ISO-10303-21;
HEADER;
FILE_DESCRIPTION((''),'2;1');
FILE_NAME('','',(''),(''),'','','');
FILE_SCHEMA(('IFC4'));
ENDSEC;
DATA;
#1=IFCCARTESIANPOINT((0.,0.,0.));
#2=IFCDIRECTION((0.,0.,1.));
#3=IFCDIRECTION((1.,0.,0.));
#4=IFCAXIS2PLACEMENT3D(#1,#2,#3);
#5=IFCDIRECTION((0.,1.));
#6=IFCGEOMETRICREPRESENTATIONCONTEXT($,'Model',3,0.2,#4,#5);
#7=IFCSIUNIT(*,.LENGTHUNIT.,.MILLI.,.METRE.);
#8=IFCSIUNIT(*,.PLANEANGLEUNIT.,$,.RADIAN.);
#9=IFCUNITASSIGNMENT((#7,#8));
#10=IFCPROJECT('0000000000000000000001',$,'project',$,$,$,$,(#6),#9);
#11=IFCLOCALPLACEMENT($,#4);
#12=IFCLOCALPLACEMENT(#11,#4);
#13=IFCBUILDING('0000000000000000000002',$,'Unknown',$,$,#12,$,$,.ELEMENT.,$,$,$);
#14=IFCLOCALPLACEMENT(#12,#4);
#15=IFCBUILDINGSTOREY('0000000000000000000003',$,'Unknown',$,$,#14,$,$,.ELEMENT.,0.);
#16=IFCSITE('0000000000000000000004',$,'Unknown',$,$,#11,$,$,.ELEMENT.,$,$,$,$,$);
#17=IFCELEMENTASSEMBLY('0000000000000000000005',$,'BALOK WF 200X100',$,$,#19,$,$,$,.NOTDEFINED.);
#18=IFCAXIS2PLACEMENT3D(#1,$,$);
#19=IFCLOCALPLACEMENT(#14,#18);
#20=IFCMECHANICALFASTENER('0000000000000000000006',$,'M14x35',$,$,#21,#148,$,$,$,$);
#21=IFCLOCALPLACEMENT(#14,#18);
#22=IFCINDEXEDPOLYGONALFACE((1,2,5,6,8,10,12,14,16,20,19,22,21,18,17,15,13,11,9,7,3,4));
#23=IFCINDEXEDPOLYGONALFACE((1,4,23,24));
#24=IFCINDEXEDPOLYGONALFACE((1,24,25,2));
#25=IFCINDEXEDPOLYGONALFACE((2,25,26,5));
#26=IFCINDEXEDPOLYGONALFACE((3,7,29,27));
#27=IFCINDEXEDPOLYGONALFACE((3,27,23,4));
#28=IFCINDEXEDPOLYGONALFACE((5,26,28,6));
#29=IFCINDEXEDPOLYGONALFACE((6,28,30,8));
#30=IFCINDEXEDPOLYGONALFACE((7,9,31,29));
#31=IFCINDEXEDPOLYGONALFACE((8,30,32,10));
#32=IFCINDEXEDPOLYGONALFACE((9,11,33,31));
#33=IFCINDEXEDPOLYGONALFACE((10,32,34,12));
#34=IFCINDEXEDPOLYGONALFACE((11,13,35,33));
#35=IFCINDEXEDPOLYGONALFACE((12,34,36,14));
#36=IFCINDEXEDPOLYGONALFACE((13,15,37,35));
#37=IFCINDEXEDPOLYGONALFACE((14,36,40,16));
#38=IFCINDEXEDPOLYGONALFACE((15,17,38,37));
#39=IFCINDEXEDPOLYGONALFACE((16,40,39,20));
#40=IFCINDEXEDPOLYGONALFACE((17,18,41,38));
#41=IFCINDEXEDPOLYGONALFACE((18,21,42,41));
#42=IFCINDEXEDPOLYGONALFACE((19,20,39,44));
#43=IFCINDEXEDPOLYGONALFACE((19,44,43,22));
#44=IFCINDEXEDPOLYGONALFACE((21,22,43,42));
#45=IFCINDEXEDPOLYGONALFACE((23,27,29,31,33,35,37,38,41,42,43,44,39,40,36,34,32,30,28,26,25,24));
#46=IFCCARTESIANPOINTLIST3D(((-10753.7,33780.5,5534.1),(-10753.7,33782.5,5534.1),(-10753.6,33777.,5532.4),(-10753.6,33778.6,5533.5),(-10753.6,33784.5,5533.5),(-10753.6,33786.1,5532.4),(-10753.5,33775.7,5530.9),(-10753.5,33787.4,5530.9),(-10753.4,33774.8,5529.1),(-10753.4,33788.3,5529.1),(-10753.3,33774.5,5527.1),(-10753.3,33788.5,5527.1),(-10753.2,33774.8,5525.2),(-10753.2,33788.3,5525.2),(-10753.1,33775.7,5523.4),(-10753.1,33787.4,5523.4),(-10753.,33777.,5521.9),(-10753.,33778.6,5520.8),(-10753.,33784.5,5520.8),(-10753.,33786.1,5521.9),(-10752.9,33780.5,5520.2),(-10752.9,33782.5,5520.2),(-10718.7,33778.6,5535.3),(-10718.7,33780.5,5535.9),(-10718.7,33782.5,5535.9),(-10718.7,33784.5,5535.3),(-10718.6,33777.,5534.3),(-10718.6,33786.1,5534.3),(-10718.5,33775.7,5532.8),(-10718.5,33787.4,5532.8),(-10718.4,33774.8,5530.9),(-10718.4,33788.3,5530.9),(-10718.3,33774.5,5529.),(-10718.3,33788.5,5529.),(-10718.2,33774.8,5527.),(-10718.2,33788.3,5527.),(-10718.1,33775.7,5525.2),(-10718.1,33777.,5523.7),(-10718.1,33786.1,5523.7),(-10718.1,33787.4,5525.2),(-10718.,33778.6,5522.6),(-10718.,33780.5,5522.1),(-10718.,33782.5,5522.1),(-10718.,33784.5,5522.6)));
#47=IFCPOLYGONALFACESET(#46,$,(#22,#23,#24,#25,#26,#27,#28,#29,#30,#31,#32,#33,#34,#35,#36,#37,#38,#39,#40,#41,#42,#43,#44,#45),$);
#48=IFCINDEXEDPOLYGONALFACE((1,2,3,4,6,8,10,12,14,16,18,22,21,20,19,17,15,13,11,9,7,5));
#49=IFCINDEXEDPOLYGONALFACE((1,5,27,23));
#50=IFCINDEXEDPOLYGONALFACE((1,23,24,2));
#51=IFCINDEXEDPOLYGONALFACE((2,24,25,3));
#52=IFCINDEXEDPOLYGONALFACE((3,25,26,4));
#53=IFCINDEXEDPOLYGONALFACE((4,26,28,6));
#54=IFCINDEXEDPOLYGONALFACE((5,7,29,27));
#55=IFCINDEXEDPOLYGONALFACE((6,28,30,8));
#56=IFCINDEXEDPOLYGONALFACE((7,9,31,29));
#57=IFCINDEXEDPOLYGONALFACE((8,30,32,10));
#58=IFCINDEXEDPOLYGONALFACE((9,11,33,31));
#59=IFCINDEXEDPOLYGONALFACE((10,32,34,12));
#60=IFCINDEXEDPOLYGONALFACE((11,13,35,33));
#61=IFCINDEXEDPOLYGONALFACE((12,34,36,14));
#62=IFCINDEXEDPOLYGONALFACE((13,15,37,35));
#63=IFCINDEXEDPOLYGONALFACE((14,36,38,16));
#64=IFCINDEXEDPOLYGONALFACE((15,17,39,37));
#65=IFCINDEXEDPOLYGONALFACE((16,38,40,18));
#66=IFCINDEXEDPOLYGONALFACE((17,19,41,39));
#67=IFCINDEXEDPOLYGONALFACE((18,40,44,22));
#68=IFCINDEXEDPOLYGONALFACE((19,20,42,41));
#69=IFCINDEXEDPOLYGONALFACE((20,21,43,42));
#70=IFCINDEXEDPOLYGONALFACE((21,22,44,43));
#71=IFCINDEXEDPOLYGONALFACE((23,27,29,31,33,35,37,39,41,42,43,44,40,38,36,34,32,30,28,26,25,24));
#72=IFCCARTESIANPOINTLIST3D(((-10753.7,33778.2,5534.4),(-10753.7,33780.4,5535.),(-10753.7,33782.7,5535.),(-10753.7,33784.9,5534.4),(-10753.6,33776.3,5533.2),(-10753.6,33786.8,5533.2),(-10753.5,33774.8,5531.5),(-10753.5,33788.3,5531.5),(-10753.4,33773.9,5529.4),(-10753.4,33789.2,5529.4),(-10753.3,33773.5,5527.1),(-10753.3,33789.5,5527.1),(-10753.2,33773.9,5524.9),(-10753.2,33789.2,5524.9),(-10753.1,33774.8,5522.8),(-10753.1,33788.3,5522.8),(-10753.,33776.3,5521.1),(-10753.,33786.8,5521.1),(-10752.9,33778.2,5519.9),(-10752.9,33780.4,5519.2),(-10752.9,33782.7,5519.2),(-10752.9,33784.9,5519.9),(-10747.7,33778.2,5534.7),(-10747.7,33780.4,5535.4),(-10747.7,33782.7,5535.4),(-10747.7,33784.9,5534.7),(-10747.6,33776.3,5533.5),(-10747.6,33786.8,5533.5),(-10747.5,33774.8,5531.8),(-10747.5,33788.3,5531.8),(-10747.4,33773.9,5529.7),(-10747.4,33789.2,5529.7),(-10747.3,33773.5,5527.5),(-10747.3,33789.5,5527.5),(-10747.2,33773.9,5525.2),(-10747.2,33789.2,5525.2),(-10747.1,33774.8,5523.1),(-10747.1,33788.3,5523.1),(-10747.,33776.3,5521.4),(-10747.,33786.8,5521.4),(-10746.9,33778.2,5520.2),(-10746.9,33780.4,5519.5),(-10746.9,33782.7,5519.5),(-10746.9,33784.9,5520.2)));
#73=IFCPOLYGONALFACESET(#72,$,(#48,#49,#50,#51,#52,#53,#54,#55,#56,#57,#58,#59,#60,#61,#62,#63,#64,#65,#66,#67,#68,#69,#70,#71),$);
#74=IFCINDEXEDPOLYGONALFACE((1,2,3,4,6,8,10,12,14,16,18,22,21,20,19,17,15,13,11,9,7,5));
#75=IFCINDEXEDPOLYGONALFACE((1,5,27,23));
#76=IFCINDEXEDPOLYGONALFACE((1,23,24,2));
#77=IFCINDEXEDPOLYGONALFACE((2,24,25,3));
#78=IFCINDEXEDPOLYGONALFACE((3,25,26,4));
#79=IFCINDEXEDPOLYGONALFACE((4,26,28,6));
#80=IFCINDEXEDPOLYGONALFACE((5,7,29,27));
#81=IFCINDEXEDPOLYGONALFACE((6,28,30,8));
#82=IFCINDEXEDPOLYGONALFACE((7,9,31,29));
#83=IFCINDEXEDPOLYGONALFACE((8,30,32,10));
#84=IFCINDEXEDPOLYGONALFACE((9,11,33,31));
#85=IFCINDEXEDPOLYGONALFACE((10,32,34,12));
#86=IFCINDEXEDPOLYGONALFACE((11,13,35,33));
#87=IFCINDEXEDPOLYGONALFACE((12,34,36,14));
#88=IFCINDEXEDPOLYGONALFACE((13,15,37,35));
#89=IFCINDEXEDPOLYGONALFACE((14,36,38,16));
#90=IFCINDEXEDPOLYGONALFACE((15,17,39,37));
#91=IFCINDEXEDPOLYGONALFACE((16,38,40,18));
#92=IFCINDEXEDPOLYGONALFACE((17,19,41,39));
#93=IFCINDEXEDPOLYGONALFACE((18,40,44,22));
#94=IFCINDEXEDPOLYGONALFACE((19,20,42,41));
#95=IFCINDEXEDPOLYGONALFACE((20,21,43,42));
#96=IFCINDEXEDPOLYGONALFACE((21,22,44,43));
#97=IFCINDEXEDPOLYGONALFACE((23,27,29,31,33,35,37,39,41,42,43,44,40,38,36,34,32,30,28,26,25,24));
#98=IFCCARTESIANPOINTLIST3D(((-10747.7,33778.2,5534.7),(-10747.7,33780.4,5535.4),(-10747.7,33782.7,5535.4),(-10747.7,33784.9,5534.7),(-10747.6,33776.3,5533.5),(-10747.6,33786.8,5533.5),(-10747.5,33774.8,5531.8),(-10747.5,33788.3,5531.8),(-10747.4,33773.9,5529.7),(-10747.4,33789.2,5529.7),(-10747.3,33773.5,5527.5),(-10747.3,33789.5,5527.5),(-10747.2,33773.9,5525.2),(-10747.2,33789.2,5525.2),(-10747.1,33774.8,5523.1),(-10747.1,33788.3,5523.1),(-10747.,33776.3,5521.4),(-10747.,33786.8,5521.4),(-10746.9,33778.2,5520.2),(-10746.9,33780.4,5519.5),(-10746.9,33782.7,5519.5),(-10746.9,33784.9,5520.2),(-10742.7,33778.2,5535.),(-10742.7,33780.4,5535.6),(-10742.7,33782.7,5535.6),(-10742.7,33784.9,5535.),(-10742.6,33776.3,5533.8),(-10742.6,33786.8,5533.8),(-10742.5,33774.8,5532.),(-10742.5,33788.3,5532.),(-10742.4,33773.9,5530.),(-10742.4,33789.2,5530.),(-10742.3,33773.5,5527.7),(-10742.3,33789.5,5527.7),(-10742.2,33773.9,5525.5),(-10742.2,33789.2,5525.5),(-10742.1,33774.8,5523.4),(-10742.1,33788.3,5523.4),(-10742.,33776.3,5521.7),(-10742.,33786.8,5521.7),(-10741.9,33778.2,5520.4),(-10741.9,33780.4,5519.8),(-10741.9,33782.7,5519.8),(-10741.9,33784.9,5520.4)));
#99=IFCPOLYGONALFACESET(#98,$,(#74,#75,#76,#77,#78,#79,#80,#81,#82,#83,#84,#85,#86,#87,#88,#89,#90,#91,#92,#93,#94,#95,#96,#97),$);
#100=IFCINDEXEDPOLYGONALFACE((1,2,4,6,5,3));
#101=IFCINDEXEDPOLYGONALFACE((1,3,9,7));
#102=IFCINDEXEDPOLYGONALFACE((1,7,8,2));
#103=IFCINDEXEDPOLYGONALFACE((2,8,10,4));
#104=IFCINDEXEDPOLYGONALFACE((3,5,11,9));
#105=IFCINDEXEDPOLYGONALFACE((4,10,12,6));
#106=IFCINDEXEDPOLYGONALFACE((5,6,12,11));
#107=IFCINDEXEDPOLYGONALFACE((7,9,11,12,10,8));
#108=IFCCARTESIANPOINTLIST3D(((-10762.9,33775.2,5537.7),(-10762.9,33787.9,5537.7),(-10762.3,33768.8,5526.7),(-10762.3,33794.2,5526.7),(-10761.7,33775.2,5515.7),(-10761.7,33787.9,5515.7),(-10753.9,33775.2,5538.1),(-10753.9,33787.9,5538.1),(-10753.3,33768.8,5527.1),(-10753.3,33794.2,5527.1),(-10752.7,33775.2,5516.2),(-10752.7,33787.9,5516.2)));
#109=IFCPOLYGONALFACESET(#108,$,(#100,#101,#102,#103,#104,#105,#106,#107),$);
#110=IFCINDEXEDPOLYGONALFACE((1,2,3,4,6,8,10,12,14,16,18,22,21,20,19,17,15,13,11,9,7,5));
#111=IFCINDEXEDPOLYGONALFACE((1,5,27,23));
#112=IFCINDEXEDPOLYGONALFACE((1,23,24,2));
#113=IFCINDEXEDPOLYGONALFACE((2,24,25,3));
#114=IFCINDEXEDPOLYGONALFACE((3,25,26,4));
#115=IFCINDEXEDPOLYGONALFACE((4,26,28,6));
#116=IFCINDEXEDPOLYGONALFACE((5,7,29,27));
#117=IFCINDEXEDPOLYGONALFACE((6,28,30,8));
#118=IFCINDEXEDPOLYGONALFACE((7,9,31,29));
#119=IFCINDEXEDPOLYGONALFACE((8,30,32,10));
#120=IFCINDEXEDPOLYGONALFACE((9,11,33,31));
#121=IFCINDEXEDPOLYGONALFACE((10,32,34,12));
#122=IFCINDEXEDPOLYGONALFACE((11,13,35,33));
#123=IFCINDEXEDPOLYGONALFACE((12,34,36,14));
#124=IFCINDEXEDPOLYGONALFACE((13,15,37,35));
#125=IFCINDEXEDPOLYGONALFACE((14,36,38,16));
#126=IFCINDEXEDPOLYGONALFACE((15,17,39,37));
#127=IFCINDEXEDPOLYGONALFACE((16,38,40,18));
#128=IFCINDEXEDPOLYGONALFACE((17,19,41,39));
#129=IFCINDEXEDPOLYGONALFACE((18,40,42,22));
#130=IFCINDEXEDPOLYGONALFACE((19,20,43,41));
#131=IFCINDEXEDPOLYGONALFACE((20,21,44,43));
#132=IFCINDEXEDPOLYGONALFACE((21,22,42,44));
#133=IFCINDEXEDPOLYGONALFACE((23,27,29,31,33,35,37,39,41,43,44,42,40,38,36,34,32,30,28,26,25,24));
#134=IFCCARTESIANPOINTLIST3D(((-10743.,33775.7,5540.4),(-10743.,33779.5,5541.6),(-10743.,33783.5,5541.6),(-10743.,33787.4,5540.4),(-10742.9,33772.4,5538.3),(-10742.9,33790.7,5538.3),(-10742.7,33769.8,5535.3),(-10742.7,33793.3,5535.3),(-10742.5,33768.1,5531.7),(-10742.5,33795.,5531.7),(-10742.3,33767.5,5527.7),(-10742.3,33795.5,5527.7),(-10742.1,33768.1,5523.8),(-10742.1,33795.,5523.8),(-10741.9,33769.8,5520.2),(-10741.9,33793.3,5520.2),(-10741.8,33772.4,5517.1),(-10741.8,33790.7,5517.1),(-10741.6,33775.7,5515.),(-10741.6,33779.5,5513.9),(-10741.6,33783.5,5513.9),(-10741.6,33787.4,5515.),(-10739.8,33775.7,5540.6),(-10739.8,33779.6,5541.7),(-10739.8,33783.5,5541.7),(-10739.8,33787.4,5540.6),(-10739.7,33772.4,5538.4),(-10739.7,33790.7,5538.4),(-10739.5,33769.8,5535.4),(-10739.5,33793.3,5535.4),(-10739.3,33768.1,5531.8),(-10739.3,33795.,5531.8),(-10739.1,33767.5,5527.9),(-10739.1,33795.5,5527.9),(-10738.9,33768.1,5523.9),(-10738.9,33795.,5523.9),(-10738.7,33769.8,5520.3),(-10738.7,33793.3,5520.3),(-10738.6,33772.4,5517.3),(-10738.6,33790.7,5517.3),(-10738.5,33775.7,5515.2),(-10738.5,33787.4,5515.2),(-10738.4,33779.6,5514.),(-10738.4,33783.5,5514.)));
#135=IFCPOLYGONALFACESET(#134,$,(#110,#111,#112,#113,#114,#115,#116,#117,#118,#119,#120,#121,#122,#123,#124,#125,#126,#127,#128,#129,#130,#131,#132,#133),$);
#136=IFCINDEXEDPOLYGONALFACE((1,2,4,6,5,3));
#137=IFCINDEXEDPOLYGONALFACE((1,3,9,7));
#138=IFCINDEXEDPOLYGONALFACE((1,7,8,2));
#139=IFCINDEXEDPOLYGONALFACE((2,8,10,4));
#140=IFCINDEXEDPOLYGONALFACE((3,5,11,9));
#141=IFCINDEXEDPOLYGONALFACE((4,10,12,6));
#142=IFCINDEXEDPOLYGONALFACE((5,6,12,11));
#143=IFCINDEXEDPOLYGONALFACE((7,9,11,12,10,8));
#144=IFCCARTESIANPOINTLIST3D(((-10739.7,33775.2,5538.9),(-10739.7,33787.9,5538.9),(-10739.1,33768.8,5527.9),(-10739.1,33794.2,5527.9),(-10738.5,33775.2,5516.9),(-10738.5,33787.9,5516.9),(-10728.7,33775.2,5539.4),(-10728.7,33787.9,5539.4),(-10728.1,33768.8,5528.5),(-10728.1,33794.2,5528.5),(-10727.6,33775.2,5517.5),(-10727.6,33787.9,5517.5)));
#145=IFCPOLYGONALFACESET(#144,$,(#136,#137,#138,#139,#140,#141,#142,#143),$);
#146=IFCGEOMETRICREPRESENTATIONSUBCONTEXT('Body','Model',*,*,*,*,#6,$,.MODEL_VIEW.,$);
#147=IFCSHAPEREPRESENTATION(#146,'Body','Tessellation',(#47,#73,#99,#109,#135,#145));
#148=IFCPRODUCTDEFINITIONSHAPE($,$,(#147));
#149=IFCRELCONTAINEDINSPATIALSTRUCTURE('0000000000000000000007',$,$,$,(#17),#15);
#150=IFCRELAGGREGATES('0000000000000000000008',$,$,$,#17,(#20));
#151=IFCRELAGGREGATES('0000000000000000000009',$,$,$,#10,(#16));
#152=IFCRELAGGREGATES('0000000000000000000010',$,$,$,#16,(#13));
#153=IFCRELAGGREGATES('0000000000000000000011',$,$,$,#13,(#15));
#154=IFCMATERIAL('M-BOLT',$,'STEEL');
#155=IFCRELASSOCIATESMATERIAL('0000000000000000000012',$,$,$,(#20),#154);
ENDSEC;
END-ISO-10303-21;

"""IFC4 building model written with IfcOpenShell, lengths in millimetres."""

from ifc_helpers import new_model, si_unit, direction, frame, origin_with_axes, place, context, subcontext, project, spatial, line, arc, indexed_curve, outline, extrude, source, transform, mapped, material, element, aggregate, save


model = new_model("IFC4")

# Units and contexts
model_context = context("Model", 3, precision=0.2, world=origin_with_axes(), true_north=direction((0.0, 1.0)))
body_context = subcontext(model_context, "Body", "Model", "MODEL_VIEW")
ifc_project = project(units=[si_unit("LENGTHUNIT", "METRE", prefix="MILLI"), si_unit("PLANEANGLEUNIT", "RADIAN")], contexts=[model_context])

# Site, building, storey
site_placement = place(None, origin_with_axes())
site = spatial("IfcSite", under=ifc_project, at=site_placement, Name="Unknown", CompositionType="ELEMENT")
building_placement = place(site_placement, origin_with_axes())
building = spatial("IfcBuilding", under=site, at=building_placement, Name="Unknown", CompositionType="ELEMENT")
storey_placement = place(building_placement, origin_with_axes())
storey = spatial("IfcBuildingStorey", under=building, at=storey_placement, Name="Unknown", CompositionType="ELEMENT", Elevation=0.0)

# Shared definitions
ifc_material_1 = material(Name="M-BOLT", Category="STEEL")

# Element assembly
assembly_1_placement = place(storey_placement, frame((-7044.1, 33866.5, 5721.5), z_axis=(0.0, 1.0, 0.0), x_axis=(-0.99863, 0.0, -0.052336)))
assembly_1 = element("IfcElementAssembly", 1, at=assembly_1_placement, inside=storey, Name="BALOK WF 200X100", PredefinedType="NOTDEFINED")

# Mechanical fastener
shared_shape_1 = source(origin_with_axes(), body_context, "Body", "SweptSolid", [
    extrude(outline(indexed_curve([(7.0, 0.0), (0.0, 7.0), (-7.0, 0.0), (0.0, -7.0)], segments=[arc(1, 2, 3), arc(3, 4, 1)])), frame((0.0, 0.0, -2.6), z_axis=(0.0, 0.0, -1.0), x_axis=(0.0, 1.0, 0.0)), (0.0, 0.0, 1.0), 35.0),
    extrude(outline(indexed_curve([(8.0, 0.0), (0.0, 8.0), (-8.0, 0.0), (0.0, -8.0)], segments=[arc(1, 2, 3), arc(3, 4, 1)])), frame((0.0, 0.0, -2.6), z_axis=(0.0, 0.0, -1.0), x_axis=(0.0, 1.0, 0.0)), (0.0, 0.0, 1.0), 6.0),
    extrude(outline(indexed_curve([(8.0, 0.0), (0.0, 8.0), (-8.0, 0.0), (0.0, -8.0)], segments=[arc(1, 2, 3), arc(3, 4, 1)])), frame((0.0, 0.0, -8.6), z_axis=(0.0, 0.0, -1.0), x_axis=(0.0, 1.0, 0.0)), (0.0, 0.0, 1.0), 5.0),
    extrude(outline(indexed_curve([(12.7, 0.0), (6.4, 11.0), (-6.4, 11.0), (-12.7, 0.0), (-6.4, -11.0), (6.4, -11.0)], segments=[line(1, 2, 3, 4, 5, 6, 1)])), frame((0.0, 0.0, 6.4), z_axis=(0.0, 0.0, -1.0), x_axis=(0.0, 1.0, 0.0)), (0.0, 0.0, 1.0), 9.0),
    extrude(outline(indexed_curve([(14.0, 0.0), (0.0, 14.0), (-14.0, 0.0), (0.0, -14.0)], segments=[arc(1, 2, 3), arc(3, 4, 1)])), frame((0.0, 0.0, -13.6), z_axis=(0.0, 0.0, -1.0), x_axis=(0.0, 1.0, 0.0)), (0.0, 0.0, 1.0), 3.2),
    extrude(outline(indexed_curve([(12.7, 0.0), (6.4, 11.0), (-6.4, 11.0), (-12.7, 0.0), (-6.4, -11.0), (6.4, -11.0)], segments=[line(1, 2, 3, 4, 5, 6, 1)])), frame((0.0, 0.0, -16.8), z_axis=(0.0, 0.0, -1.0), x_axis=(0.0, 1.0, 0.0)), (0.0, 0.0, 1.0), 11.0),
])
mechanical_fastener_1_placement = place(assembly_1_placement, frame((3716.9, 0.1, -85.0), z_axis=(1.0, 0.0, -0.000006), x_axis=(0.0, -1.0, 0.0)))
mechanical_fastener_1 = element("IfcMechanicalFastener", 2, at=mechanical_fastener_1_placement, material=ifc_material_1, Name="M14x35", context=body_context, shape_type="MappedRepresentation", body=[
    mapped(shared_shape_1, transform((0.0, 0.0, 0.0))),
])
aggregate(assembly_1, [mechanical_fastener_1])

save(model, "model.ifc")
